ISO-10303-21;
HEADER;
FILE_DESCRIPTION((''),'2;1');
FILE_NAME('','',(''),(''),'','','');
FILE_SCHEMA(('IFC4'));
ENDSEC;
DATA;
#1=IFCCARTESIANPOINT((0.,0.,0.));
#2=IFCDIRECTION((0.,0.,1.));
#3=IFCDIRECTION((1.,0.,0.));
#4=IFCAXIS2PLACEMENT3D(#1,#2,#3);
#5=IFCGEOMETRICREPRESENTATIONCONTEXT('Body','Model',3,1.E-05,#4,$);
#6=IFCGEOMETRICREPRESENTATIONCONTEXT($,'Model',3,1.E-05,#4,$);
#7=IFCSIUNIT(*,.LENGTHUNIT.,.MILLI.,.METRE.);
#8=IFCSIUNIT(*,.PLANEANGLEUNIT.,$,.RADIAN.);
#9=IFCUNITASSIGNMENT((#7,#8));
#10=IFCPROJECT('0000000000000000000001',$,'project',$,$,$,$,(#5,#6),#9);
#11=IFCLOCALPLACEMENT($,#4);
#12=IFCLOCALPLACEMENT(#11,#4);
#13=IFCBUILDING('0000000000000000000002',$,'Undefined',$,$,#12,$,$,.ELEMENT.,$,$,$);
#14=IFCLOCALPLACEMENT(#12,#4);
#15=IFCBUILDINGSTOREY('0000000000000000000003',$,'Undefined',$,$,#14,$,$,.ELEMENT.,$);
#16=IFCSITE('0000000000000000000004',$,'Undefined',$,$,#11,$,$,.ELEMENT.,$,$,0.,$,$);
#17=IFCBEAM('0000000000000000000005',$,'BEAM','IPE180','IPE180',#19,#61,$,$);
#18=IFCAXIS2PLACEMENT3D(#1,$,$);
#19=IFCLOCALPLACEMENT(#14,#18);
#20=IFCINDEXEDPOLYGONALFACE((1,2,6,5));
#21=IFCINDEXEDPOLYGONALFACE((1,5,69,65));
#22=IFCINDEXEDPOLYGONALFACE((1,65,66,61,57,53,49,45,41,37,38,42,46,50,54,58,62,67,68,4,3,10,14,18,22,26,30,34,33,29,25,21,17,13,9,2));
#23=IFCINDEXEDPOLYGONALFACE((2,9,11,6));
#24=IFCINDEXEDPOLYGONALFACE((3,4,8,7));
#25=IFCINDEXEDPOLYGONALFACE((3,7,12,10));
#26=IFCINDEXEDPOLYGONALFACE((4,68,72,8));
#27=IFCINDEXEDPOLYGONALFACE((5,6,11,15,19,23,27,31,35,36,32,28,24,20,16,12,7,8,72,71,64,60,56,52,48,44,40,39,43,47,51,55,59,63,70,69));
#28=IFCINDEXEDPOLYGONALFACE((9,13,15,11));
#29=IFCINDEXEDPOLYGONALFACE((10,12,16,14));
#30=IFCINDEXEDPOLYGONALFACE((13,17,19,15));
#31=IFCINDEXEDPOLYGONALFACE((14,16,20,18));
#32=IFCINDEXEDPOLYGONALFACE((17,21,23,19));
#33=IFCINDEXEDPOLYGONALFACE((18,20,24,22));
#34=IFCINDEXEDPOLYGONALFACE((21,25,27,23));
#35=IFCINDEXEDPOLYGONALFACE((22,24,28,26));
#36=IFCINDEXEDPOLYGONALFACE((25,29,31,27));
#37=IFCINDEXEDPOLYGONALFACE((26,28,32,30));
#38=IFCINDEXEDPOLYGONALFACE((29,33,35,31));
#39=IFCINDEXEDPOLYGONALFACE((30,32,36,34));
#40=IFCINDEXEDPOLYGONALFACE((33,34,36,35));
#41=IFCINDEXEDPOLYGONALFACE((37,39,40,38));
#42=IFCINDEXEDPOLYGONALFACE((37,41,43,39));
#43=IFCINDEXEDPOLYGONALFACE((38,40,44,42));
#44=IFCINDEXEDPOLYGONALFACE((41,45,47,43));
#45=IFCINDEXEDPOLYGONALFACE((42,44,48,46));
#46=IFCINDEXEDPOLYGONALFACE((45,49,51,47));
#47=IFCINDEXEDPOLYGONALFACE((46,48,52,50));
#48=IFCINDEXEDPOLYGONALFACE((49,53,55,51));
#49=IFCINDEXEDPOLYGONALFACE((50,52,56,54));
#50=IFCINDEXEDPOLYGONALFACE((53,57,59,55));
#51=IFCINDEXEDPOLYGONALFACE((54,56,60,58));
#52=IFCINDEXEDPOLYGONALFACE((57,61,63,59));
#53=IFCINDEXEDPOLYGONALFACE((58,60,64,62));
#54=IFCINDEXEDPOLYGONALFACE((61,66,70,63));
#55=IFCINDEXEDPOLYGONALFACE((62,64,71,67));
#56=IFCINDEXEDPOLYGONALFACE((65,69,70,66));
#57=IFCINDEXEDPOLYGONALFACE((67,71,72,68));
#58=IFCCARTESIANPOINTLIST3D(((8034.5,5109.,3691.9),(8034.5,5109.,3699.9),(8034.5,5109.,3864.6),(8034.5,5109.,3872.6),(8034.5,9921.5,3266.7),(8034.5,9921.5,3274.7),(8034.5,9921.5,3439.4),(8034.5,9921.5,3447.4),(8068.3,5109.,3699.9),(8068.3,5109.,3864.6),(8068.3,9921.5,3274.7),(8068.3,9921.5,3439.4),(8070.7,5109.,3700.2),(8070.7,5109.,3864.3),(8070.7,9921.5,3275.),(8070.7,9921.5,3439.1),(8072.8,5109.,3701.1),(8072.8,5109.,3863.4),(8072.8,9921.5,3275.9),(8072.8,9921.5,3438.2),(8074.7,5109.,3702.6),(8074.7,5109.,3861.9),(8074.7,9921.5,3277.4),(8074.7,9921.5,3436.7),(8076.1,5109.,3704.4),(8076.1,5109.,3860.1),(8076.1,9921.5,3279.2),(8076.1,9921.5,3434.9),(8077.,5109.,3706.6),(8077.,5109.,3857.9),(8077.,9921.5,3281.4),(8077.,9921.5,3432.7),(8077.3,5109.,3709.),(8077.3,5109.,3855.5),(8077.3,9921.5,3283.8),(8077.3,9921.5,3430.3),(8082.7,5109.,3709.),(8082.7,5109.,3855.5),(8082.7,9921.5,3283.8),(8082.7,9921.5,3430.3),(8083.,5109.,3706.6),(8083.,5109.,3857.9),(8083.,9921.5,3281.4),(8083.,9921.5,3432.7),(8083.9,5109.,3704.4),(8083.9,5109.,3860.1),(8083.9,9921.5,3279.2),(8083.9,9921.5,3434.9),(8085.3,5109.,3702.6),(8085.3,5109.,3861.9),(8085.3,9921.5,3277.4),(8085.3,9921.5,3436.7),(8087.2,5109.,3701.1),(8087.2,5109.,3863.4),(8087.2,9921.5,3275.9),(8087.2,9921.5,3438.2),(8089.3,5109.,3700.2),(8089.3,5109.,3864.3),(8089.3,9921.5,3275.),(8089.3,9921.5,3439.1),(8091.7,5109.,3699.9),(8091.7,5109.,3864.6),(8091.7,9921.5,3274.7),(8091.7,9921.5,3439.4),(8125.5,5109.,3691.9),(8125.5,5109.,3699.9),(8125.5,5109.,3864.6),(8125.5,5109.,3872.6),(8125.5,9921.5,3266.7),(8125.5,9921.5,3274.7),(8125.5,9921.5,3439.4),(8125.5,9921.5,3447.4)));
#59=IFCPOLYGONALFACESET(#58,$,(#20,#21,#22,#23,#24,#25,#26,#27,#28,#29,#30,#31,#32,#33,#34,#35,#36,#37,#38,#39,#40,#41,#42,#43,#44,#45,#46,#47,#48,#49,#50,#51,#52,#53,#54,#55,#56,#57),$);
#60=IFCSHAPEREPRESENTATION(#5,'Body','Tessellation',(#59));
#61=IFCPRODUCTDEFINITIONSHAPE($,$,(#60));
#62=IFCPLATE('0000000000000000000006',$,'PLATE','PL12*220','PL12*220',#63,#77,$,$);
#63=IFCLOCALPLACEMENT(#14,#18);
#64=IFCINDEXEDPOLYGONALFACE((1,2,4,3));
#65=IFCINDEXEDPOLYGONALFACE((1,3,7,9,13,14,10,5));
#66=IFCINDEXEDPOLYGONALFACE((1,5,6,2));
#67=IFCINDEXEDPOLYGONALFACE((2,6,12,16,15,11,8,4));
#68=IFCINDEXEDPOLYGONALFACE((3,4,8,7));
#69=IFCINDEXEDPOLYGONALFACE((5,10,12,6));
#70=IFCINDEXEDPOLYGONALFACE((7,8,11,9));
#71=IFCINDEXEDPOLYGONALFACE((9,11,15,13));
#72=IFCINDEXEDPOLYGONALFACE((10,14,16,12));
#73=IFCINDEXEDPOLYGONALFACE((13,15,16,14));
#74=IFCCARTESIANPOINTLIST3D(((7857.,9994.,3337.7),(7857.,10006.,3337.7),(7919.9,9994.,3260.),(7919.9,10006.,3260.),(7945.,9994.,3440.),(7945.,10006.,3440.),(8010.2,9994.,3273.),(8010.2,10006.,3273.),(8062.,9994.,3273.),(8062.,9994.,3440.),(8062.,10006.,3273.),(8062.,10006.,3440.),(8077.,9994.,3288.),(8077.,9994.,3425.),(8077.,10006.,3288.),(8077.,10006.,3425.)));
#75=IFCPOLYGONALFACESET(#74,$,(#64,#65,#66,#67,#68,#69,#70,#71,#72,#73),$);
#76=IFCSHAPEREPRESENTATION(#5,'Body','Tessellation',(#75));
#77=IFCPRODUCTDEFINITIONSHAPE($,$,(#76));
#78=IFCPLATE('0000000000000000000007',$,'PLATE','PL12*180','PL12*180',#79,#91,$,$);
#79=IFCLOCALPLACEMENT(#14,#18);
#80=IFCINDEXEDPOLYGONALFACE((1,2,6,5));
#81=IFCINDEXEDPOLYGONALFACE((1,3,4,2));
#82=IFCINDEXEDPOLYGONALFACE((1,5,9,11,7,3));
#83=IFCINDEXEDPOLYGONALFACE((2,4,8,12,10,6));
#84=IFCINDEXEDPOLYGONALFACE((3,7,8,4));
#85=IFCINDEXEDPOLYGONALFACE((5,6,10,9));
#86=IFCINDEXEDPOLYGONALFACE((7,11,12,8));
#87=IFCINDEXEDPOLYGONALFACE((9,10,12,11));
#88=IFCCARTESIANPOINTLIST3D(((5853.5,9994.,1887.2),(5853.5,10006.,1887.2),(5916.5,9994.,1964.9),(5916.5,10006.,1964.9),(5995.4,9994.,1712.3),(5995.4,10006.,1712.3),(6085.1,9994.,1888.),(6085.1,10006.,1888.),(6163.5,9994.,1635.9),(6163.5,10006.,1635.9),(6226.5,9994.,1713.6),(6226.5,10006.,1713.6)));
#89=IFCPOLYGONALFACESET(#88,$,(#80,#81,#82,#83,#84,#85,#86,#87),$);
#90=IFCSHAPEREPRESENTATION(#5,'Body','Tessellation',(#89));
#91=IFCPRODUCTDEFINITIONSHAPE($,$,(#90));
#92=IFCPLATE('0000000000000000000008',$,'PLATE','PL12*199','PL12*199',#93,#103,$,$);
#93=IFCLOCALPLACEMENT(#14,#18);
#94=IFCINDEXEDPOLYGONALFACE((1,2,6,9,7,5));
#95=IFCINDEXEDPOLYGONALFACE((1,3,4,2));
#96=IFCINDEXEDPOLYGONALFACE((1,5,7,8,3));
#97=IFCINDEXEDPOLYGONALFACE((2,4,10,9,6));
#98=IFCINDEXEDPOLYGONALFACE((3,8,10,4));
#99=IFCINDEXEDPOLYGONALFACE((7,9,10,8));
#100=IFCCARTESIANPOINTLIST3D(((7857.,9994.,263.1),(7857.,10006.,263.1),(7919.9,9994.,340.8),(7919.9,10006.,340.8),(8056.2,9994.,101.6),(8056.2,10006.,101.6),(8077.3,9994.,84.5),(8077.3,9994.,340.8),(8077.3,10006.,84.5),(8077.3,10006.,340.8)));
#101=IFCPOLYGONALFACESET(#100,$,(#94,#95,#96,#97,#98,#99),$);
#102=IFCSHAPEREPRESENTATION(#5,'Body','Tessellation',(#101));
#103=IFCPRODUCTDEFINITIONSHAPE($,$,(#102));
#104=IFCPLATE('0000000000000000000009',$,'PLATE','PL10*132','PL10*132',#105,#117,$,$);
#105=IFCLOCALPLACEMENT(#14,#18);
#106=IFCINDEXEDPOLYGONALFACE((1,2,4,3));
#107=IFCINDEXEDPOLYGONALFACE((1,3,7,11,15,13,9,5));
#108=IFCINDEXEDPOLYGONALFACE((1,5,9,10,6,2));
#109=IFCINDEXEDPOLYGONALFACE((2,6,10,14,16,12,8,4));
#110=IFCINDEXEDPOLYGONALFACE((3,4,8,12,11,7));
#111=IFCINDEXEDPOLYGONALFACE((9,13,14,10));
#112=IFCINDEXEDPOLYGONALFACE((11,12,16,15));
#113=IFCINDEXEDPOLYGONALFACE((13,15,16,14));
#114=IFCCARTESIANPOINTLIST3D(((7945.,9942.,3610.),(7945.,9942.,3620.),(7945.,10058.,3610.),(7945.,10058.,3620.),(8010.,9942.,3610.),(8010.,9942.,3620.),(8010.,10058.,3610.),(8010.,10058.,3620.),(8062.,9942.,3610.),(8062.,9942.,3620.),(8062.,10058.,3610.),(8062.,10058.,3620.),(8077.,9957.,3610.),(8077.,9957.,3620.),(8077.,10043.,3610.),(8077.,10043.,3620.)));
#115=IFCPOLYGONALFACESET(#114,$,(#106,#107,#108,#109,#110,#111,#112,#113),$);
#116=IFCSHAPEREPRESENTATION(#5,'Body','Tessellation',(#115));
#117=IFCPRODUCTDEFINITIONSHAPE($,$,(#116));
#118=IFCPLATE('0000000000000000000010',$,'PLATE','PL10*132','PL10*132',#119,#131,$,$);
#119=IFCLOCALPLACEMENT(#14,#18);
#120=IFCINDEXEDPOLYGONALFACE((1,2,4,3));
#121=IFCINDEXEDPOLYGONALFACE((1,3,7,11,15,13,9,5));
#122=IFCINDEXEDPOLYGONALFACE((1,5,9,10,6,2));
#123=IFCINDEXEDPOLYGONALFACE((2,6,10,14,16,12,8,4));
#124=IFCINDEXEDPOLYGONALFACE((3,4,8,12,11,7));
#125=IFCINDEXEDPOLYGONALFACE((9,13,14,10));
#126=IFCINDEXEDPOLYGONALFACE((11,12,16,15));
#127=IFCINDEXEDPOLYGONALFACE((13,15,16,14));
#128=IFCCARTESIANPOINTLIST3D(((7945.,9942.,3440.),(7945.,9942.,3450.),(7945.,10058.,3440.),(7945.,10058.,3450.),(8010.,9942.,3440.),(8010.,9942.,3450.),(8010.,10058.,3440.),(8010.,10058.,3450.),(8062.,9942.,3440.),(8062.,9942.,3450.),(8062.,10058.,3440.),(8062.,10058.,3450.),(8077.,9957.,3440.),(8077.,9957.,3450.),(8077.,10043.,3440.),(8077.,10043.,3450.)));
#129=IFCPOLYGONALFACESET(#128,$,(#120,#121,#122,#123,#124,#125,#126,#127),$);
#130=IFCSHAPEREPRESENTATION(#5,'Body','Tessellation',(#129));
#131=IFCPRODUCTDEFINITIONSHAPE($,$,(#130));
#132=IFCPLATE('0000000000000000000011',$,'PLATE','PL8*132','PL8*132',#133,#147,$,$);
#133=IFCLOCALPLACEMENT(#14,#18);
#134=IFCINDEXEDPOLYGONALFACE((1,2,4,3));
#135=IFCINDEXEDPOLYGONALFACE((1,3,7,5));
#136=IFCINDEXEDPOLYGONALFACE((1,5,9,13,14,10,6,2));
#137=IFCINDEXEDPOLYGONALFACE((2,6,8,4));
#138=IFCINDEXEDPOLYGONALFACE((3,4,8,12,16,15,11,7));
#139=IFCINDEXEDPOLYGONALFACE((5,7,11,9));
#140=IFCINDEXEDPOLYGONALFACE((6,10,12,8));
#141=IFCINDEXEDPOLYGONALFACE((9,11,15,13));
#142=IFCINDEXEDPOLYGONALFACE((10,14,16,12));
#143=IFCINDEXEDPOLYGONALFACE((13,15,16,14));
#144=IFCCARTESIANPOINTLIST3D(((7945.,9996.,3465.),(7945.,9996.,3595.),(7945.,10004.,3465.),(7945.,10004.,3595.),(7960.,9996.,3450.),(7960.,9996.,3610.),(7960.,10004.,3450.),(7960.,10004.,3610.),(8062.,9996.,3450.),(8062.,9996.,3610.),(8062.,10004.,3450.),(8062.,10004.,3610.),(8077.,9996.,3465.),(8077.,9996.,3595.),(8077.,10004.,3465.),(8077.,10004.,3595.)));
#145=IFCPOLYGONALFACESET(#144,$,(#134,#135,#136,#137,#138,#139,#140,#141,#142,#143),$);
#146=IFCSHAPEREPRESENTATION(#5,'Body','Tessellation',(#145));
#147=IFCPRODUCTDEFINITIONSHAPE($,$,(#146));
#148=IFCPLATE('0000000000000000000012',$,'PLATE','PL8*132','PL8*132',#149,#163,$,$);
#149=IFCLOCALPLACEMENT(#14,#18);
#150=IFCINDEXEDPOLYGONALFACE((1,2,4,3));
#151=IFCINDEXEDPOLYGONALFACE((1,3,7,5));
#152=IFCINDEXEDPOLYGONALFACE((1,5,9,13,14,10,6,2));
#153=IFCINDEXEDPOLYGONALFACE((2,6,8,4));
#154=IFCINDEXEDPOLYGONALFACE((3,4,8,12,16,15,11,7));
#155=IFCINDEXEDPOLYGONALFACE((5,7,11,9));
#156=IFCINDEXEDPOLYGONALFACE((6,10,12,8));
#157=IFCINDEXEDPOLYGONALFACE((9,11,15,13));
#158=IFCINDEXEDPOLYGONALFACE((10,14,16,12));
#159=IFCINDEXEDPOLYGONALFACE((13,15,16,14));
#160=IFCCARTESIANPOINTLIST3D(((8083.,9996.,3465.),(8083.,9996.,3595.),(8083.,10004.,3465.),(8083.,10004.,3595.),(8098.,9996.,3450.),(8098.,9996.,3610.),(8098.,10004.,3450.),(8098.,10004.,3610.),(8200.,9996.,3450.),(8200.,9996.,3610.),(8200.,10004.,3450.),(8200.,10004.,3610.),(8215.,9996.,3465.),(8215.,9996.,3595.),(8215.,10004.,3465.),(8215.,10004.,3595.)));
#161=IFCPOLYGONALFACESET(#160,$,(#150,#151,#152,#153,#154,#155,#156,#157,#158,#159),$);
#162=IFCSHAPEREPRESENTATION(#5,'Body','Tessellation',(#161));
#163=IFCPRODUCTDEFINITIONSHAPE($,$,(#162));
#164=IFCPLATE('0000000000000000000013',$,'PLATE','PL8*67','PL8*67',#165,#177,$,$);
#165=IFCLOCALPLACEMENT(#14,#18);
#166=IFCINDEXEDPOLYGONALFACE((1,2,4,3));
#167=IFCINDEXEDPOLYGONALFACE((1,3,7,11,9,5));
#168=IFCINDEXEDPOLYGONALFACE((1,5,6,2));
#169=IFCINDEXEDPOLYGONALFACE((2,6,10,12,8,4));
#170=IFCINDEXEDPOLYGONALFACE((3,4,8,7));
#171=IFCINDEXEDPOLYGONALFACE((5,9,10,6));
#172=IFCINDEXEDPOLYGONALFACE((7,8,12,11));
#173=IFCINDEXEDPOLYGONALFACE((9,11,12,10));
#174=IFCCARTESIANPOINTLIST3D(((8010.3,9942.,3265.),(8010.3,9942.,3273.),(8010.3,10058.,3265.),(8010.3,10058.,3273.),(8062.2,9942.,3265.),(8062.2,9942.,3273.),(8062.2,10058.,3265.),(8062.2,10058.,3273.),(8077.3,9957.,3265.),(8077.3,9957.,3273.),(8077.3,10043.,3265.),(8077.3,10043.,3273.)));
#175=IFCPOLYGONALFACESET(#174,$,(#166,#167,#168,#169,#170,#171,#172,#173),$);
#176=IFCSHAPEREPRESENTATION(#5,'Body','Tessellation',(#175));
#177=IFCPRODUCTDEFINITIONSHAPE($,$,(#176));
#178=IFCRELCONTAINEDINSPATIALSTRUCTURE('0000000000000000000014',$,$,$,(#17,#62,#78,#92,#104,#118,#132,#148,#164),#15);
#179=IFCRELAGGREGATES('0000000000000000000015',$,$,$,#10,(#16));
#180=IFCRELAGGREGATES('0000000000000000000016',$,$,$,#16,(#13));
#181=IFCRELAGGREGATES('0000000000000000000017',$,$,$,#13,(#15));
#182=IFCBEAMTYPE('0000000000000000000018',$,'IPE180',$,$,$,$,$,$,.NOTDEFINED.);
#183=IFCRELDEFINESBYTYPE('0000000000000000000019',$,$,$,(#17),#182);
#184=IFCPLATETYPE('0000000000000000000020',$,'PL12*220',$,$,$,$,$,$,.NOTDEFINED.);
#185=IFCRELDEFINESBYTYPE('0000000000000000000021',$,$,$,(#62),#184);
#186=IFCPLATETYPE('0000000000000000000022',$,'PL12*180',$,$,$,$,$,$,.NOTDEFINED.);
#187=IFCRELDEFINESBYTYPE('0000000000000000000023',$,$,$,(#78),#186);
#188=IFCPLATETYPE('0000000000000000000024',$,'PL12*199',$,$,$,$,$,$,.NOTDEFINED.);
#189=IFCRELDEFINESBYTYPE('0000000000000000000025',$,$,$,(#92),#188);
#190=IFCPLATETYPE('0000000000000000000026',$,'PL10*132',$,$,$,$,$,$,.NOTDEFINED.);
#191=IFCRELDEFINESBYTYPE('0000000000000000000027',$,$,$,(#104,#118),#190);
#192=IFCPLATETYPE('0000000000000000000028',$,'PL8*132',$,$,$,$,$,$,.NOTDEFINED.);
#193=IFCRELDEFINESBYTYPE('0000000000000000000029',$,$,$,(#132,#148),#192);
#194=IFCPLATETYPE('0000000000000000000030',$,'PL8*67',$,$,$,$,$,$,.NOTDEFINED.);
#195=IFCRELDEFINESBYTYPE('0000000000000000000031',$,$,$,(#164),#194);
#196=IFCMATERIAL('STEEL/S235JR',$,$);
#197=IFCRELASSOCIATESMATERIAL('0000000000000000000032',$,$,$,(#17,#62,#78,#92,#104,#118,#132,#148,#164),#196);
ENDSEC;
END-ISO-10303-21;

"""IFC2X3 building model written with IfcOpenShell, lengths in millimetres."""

from ifc_helpers import new_model, si_unit, frame, origin_with_axes, origin_2d_with_axis, place, context, project, spatial, polyline, i_section, outline, extrude, clip, halfspace, material, type_object, element, save


model = new_model("IFC2X3")

# Units and contexts
model_context_1 = context("Model", 3, precision=1e-05, world=origin_with_axes(), identifier="Body")
model_context_2 = context("Model", 3, precision=1e-05, world=origin_with_axes())
ifc_project = project(units=[si_unit("LENGTHUNIT", "METRE", prefix="MILLI"), si_unit("PLANEANGLEUNIT", "RADIAN")], contexts=[model_context_1, model_context_2])

# Site, building, storey
site_placement = place(None, origin_with_axes())
site = spatial("IfcSite", under=ifc_project, at=site_placement, Name="Undefined", CompositionType="ELEMENT", RefElevation=0.0)
building_placement = place(site_placement, origin_with_axes())
building = spatial("IfcBuilding", under=site, at=building_placement, Name="Undefined", CompositionType="ELEMENT")
storey_placement = place(building_placement, origin_with_axes())
storey = spatial("IfcBuildingStorey", under=building, at=storey_placement, Name="Undefined", CompositionType="ELEMENT")

# Shared definitions
ifc_material = material(Name="STEEL/S235JR")

# Beam
beam_type_1 = type_object("IfcBeamType", Name="IPE180", PredefinedType="NOTDEFINED")
beam_1_placement = place(storey_placement, frame((8080.0, 9941.1, 3355.3), z_axis=(0.0, 0.08801, 0.99612), x_axis=(0.0, -0.99612, 0.08801)))
element("IfcBeam", 1, at=beam_1_placement, inside=storey, type_object=beam_type_1, material=ifc_material, Name="BEAM", Description="IPE180", ObjectType="IPE180", context=model_context_1, shape_type="Clipping", body=[
    clip(clip(extrude(i_section(OverallWidth=91.0, OverallDepth=180.0, WebThickness=5.3, FlangeThickness=8.0, FilletRadius=9.0, at=origin_2d_with_axis()), frame((4867.0, 0.0, 0.0), z_axis=(-1.0, 0.0, 0.0), x_axis=(0.0, -1.0, 0.0)), (0.0, 0.0, 1.0), 4863.4), halfspace(frame((11.7, 0.0, -90.0), z_axis=(0.99612, 0.0, -0.08801), x_axis=(0.0, -1.0, 0.0)), True)), halfspace(frame((4843.1, 0.0, -88.9), z_axis=(-0.99612, 0.0, 0.08801), x_axis=(0.0, 1.0, 0.0)), True)),
])

# Plates
plate_type_1 = type_object("IfcPlateType", Name="PL12*220", PredefinedType="NOTDEFINED")
plate_1_placement = place(storey_placement, frame((8077.0, 10000.0, 3440.0), z_axis=(0.0, -1.0, 0.0), x_axis=(-1.0, 0.0, 0.0)))
element("IfcPlate", 2, at=plate_1_placement, inside=storey, type_object=plate_type_1, material=ifc_material, Name="PLATE", Description="PL12*220", ObjectType="PL12*220", context=model_context_1, shape_type="SweptSolid", body=[
    extrude(outline(polyline([(0.0, 15.0), (15.0, 0.0), (132.0, 0.0), (220.0, 102.3), (157.1, 180.0), (66.8, 167.0), (15.0, 167.0), (0.0, 152.0), (0.0, 15.0)])), frame((0.0, 0.0, -6.0), z_axis=(0.0, 0.0, 1.0), x_axis=(1.0, 0.0, 0.0)), (0.0, 0.0, 1.0), 12.0),
])
plate_type_2 = type_object("IfcPlateType", Name="PL12*180", PredefinedType="NOTDEFINED")
plate_2_placement = place(storey_placement, frame((6226.5, 10000.0, 1713.6), z_axis=(0.0, -1.0, 0.0), x_axis=(-0.629835, 0.0, 0.776729)))
element("IfcPlate", 3, at=plate_2_placement, inside=storey, type_object=plate_type_2, material=ifc_material, Name="PLATE", Description="PL12*180", ObjectType="PL12*180", context=model_context_1, shape_type="SweptSolid", body=[
    extrude(outline(polyline([(0.0, 0.0), (224.6, 0.0), (390.5, 82.5), (369.8, 180.3), (144.6, 180.3), (-20.7, 97.8), (0.0, 0.0)])), frame((0.0, 0.0, -6.0), z_axis=(0.0, 0.0, 1.0), x_axis=(1.0, 0.0, 0.0)), (0.0, 0.0, 1.0), 12.0),
])
plate_type_3 = type_object("IfcPlateType", Name="PL12*199", PredefinedType="NOTDEFINED")
plate_3_placement = place(storey_placement, frame((8077.3, 10000.0, 84.5), z_axis=(0.0, -1.0, 0.0), x_axis=(0.0, 0.0, 1.0)))
element("IfcPlate", 4, at=plate_3_placement, inside=storey, type_object=plate_type_3, material=ifc_material, Name="PLATE", Description="PL12*199", ObjectType="PL12*199", context=model_context_1, shape_type="SweptSolid", body=[
    extrude(outline(polyline([(0.0, 0.0), (256.3, 0.0), (256.3, 157.3), (178.6, 220.3), (17.1, 21.1), (0.0, 0.0)])), frame((0.0, 0.0, -6.0), z_axis=(0.0, 0.0, 1.0), x_axis=(1.0, 0.0, 0.0)), (0.0, 0.0, 1.0), 12.0),
])
plate_type_4 = type_object("IfcPlateType", Name="PL10*132", PredefinedType="NOTDEFINED")
for number, where, z_axis, x_axis, name in (
    (5, (8077.0, 10058.0, 3615.0), (0.0, 0.0, 1.0), (-1.0, 0.0, 0.0), "PLATE"),
    (6, (8077.0, 10058.0, 3445.0), (0.0, 0.0, 1.0), (-1.0, 0.0, 0.0), "PLATE"),
):
    element("IfcPlate", number, at=place(storey_placement, frame(where, z_axis=z_axis, x_axis=x_axis)), inside=storey, type_object=plate_type_4, material=ifc_material, Name=name, Description="PL10*132", ObjectType="PL10*132", context=model_context_1, shape_type="SweptSolid", body=[
        extrude(outline(polyline([(0.0, 15.0), (15.0, 0.0), (67.0, 0.0), (132.0, 0.0), (132.0, 116.0), (67.0, 116.0), (15.0, 116.0), (0.0, 101.0), (0.0, 15.0)])), frame((0.0, 0.0, -5.0), z_axis=(0.0, 0.0, 1.0), x_axis=(1.0, 0.0, 0.0)), (0.0, 0.0, 1.0), 10.0),
    ])
plate_type_5 = type_object("IfcPlateType", Name="PL8*132", PredefinedType="NOTDEFINED")
for number, where, z_axis, x_axis, name in (
    (7, (8077.0, 10000.0, 3610.0), (0.0, -1.0, 0.0), (-1.0, 0.0, 0.0), "PLATE"),
    (8, (8083.0, 10000.0, 3610.0), (0.0, 1.0, 0.0), (1.0, 0.0, 0.0), "PLATE"),
):
    element("IfcPlate", number, at=place(storey_placement, frame(where, z_axis=z_axis, x_axis=x_axis)), inside=storey, type_object=plate_type_5, material=ifc_material, Name=name, Description="PL8*132", ObjectType="PL8*132", context=model_context_1, shape_type="SweptSolid", body=[
        extrude(outline(polyline([(0.0, 15.0), (15.0, 0.0), (117.0, 0.0), (132.0, 15.0), (132.0, 145.0), (117.0, 160.0), (15.0, 160.0), (0.0, 145.0), (0.0, 15.0)])), frame((0.0, 0.0, -4.0), z_axis=(0.0, 0.0, 1.0), x_axis=(1.0, 0.0, 0.0)), (0.0, 0.0, 1.0), 8.0),
    ])
plate_type_6 = type_object("IfcPlateType", Name="PL8*67", PredefinedType="NOTDEFINED")
plate_4_placement = place(storey_placement, frame((8010.2, 9942.0, 3269.0), z_axis=(0.0, 0.0, 1.0), x_axis=(1.0, 0.0, 0.0)))
element("IfcPlate", 9, at=plate_4_placement, inside=storey, type_object=plate_type_6, material=ifc_material, Name="PLATE", Description="PL8*67", ObjectType="PL8*67", context=model_context_1, shape_type="SweptSolid", body=[
    extrude(outline(polyline([(0.0, 0.0), (52.0, 0.0), (67.0, 15.0), (67.0, 101.0), (52.0, 116.0), (0.0, 116.0), (0.0, 0.0)])), frame((0.0, 0.0, -4.0), z_axis=(0.0, 0.0, 1.0), x_axis=(1.0, 0.0, 0.0)), (0.0, 0.0, 1.0), 8.0),
])

save(model, "model.ifc")
